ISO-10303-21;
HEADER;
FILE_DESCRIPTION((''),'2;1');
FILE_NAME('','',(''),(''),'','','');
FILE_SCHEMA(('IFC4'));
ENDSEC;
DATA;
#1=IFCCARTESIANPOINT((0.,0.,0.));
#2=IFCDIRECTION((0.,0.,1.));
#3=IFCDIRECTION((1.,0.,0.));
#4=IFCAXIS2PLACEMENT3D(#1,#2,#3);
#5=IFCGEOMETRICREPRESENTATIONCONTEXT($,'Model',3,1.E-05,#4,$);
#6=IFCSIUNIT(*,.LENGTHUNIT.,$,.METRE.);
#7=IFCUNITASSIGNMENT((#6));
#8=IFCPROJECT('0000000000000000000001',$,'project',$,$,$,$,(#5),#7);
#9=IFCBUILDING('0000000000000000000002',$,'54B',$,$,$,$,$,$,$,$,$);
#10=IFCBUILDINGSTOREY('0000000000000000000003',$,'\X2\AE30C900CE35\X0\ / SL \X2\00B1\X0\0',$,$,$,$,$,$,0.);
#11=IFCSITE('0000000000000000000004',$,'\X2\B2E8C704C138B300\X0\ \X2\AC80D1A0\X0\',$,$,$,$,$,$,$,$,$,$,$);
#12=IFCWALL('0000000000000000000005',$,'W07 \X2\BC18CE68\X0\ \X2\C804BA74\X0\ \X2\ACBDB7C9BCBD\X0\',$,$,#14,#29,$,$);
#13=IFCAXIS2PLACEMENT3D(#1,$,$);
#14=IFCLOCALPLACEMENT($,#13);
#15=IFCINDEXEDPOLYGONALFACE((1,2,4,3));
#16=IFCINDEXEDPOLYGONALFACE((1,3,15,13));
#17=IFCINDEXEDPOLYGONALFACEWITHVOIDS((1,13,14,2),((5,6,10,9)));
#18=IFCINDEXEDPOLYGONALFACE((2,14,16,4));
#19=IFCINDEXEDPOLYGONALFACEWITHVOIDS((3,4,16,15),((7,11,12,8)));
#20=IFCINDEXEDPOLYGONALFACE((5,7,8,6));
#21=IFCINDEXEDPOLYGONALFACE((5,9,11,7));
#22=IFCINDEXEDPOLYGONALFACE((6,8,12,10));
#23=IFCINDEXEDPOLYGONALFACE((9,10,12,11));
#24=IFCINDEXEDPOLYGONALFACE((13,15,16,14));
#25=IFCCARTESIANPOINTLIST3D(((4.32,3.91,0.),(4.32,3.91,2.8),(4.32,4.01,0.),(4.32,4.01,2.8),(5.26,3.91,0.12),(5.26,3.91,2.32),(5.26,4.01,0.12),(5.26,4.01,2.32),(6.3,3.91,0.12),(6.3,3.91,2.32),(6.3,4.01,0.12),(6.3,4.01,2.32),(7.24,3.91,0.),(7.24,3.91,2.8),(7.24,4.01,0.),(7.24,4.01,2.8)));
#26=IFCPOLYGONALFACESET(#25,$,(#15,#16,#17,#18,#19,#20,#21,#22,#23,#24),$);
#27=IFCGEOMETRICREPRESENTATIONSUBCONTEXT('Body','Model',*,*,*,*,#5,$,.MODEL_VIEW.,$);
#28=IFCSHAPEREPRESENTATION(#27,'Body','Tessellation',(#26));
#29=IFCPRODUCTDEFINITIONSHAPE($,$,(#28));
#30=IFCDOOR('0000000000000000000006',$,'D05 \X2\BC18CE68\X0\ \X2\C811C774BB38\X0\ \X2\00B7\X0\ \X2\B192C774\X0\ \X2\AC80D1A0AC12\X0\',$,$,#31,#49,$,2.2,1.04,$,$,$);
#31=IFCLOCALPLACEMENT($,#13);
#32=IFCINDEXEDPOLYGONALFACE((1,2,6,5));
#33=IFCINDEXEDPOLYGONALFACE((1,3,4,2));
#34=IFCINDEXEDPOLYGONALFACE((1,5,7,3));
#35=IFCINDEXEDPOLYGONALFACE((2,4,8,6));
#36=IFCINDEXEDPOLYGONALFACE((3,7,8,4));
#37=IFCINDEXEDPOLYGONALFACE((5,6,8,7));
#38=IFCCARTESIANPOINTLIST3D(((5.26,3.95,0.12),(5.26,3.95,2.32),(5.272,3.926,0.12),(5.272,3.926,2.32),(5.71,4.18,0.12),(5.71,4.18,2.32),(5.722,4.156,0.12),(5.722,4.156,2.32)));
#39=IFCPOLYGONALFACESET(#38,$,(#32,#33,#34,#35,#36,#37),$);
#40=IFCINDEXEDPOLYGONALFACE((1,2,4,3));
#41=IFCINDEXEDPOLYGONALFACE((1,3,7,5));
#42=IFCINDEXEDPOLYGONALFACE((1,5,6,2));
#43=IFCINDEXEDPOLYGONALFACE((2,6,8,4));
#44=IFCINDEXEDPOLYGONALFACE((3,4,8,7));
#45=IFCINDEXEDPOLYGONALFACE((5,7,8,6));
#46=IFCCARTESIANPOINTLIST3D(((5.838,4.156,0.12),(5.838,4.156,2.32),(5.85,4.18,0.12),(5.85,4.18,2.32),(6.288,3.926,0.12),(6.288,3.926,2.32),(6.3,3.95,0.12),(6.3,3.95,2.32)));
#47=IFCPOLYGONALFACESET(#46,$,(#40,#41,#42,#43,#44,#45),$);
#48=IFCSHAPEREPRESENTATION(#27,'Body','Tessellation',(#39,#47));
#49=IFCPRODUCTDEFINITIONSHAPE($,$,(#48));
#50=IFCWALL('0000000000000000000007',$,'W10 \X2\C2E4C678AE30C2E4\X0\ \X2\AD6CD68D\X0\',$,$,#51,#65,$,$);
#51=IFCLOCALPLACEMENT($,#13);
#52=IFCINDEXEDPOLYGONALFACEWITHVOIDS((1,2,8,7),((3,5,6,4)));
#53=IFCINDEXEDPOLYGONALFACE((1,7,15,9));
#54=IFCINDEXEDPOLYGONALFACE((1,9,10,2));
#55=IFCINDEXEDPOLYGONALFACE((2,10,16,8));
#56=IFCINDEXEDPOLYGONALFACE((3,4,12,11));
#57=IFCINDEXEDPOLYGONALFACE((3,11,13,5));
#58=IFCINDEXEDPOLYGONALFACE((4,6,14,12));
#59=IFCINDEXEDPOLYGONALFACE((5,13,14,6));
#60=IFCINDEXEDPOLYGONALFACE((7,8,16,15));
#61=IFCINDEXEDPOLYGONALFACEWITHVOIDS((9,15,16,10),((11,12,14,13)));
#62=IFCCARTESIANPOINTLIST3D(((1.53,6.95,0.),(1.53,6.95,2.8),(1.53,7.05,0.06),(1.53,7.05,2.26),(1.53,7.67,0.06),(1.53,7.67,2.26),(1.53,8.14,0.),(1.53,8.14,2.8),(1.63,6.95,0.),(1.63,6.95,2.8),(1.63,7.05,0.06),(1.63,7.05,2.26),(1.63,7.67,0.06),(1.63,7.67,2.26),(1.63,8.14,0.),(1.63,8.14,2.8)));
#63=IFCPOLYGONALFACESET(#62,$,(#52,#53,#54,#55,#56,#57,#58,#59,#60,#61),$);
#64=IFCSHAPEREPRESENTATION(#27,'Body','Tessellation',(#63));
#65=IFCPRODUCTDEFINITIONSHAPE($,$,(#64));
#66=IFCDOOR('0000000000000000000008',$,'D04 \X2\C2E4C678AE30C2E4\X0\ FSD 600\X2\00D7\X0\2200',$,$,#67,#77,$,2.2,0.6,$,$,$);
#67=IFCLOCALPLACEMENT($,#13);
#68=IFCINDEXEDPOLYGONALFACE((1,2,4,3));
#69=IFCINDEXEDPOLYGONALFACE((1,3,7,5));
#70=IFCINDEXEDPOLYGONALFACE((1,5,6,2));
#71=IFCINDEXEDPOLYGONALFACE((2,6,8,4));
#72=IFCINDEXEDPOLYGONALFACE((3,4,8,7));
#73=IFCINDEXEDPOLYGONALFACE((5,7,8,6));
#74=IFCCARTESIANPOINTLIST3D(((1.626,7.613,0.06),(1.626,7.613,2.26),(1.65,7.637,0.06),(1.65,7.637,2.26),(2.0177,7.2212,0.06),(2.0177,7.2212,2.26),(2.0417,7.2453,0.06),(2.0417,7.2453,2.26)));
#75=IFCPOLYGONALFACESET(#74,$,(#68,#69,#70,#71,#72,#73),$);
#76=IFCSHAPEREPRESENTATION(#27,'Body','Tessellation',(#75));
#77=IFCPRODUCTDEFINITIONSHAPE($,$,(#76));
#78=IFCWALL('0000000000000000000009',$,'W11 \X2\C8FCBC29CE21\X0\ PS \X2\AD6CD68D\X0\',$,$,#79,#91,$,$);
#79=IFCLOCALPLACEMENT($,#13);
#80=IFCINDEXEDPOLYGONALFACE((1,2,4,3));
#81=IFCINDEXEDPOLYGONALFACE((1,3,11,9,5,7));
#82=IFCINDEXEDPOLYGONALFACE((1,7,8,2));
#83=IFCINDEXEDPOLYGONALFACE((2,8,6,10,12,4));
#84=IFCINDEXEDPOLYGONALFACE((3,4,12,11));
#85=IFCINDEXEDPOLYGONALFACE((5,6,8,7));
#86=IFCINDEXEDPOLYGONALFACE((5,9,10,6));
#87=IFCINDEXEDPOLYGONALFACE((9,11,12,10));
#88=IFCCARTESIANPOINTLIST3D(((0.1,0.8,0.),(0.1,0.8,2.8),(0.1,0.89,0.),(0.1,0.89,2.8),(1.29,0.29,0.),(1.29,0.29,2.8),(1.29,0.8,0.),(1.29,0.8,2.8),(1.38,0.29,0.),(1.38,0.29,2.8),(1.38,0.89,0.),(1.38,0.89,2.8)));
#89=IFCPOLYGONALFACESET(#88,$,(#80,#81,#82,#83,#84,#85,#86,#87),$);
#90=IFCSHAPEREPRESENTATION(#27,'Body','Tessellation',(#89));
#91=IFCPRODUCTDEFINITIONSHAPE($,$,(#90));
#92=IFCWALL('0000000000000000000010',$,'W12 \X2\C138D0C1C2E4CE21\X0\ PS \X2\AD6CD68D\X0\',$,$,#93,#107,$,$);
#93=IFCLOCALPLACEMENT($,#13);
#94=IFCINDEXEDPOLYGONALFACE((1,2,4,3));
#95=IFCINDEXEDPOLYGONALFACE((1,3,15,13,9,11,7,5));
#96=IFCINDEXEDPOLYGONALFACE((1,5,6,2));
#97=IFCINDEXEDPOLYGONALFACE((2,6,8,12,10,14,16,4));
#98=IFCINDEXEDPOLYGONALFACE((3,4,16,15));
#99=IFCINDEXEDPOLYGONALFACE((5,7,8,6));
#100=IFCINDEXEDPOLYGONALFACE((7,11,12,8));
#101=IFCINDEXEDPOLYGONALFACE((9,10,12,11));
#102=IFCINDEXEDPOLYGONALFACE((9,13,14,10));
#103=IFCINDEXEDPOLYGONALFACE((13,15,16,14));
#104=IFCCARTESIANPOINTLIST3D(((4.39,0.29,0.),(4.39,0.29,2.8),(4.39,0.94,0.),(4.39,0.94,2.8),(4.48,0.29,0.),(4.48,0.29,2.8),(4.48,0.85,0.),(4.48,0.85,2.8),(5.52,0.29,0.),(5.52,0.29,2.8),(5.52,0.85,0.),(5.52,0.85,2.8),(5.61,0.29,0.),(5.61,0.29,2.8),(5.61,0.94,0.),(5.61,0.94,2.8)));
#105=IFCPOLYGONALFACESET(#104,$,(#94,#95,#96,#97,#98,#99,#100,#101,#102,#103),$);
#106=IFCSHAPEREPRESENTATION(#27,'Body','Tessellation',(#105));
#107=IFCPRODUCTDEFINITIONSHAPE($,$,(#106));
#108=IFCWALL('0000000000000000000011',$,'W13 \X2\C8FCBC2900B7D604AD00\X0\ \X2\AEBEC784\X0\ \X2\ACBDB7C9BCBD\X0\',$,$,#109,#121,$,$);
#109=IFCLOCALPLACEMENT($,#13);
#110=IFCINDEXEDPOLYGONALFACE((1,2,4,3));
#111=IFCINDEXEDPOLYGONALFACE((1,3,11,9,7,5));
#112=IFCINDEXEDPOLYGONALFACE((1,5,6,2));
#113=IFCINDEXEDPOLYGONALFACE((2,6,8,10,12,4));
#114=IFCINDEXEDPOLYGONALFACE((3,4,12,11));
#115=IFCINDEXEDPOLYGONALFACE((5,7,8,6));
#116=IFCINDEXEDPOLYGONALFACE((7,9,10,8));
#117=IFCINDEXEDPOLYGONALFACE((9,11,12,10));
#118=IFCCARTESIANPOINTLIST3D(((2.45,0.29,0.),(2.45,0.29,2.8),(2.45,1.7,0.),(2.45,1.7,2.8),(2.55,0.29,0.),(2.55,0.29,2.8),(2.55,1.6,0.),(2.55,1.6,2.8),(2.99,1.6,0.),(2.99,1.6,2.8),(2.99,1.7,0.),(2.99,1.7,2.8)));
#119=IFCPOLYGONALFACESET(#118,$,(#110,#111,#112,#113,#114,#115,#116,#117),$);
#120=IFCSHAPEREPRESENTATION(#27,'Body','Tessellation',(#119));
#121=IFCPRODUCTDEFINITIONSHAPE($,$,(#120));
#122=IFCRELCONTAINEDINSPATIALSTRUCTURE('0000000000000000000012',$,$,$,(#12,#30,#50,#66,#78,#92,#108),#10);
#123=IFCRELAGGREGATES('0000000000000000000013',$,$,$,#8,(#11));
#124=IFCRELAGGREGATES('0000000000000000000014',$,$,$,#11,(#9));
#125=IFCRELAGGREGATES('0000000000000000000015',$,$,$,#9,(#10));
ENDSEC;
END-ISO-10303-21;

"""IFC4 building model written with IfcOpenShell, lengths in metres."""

from ifc_helpers import new_model, si_unit, frame, origin, origin_with_axes, place, context, subcontext, project, spatial, polyline, outline, extrude, element, fill, save


model = new_model("IFC4")

# Units and contexts
model_context = context("Model", 3, precision=1e-05, world=origin_with_axes())
body_context = subcontext(model_context, "Body", "Model", "MODEL_VIEW")
ifc_project = project(units=[si_unit("LENGTHUNIT", "METRE")], contexts=[model_context])

# Site, building, storey
site = spatial("IfcSite", under=ifc_project, Name="단위세대 검토")
building = spatial("IfcBuilding", under=site, Name="54B")
storey = spatial("IfcBuildingStorey", under=building, Name="기준층 / SL ±0", Elevation=0.0)

# Wall, opening, door
wall_1_placement = place(None, origin_with_axes())
wall_1 = element("IfcWall", 1, at=wall_1_placement, inside=storey, Name="W07 반침 전면 경량벽", context=body_context, shape_type="SweptSolid", body=[
    extrude(outline(polyline([(7.24, 3.91), (7.24, 4.01), (4.32, 4.01), (4.32, 3.91), (7.24, 3.91)])), origin(), (0.0, 0.0, 1.0), 2.8),
])
opening_1_placement = place(wall_1_placement, origin_with_axes())
opening_1 = element("IfcOpeningElement", 2, at=opening_1_placement, cuts=wall_1, context=body_context, shape_type="SweptSolid", body=[
    extrude(outline(polyline([(6.3, 3.909), (6.3, 4.011), (5.26, 4.011), (5.26, 3.909), (6.3, 3.909)])), frame((0.0, 0.0, 0.12)), (0.0, 0.0, 1.0), 2.2),
])
door_1_placement = place(None, origin_with_axes())
door_1 = element("IfcDoor", 3, at=door_1_placement, inside=storey, Name="D05 반침 접이문 · 높이 검토값", OverallHeight=2.2, OverallWidth=1.04, context=body_context, shape_type="SweptSolid", body=[
    extrude(outline(polyline([(5.26, 3.95), (5.71, 4.18), (5.722, 4.156), (5.272, 3.926), (5.26, 3.95)])), frame((0.0, 0.0, 0.12)), (0.0, 0.0, 1.0), 2.2),
    extrude(outline(polyline([(6.3, 3.95), (5.85, 4.18), (5.838, 4.156), (6.288, 3.926), (6.3, 3.95)])), frame((0.0, 0.0, 0.12)), (0.0, 0.0, 1.0), 2.2),
])
fill(opening_1, door_1)

# Wall, opening, door
wall_2_placement = place(None, origin_with_axes())
wall_2 = element("IfcWall", 4, at=wall_2_placement, inside=storey, Name="W10 실외기실 구획", context=body_context, shape_type="SweptSolid", body=[
    extrude(outline(polyline([(1.63, 6.95), (1.63, 8.14), (1.53, 8.14), (1.53, 6.95), (1.63, 6.95)])), origin(), (0.0, 0.0, 1.0), 2.8),
])
opening_2_placement = place(wall_2_placement, origin_with_axes())
opening_2 = element("IfcOpeningElement", 5, at=opening_2_placement, cuts=wall_2, context=body_context, shape_type="SweptSolid", body=[
    extrude(outline(polyline([(1.631, 7.05), (1.631, 7.67), (1.529, 7.67), (1.529, 7.05), (1.631, 7.05)])), frame((0.0, 0.0, 0.06)), (0.0, 0.0, 1.0), 2.2),
])
door_2_placement = place(None, origin_with_axes())
door_2 = element("IfcDoor", 6, at=door_2_placement, inside=storey, Name="D04 실외기실 FSD 600×2200", OverallHeight=2.2, OverallWidth=0.6, context=body_context, shape_type="SweptSolid", body=[
    extrude(outline(polyline([(1.626, 7.613), (1.65, 7.637), (2.0417, 7.2453), (2.0177, 7.2212), (1.626, 7.613)])), frame((0.0, 0.0, 0.06)), (0.0, 0.0, 1.0), 2.2),
])
fill(opening_2, door_2)

# Walls
wall_3_placement = place(None, origin_with_axes())
element("IfcWall", 7, at=wall_3_placement, inside=storey, Name="W11 주방측 PS 구획", context=body_context, shape_type="SweptSolid", body=[
    extrude(outline(polyline([(1.29, 0.29), (1.38, 0.29), (1.38, 0.89), (0.1, 0.89), (0.1, 0.8), (1.29, 0.8), (1.29, 0.29)])), origin(), (0.0, 0.0, 1.0), 2.8),
])
wall_4_placement = place(None, origin_with_axes())
element("IfcWall", 8, at=wall_4_placement, inside=storey, Name="W12 세탁실측 PS 구획", context=body_context, shape_type="SweptSolid", body=[
    extrude(outline(polyline([(4.39, 0.29), (4.48, 0.29), (4.48, 0.85), (5.52, 0.85), (5.52, 0.29), (5.61, 0.29), (5.61, 0.94), (4.39, 0.94), (4.39, 0.29)])), origin(), (0.0, 0.0, 1.0), 2.8),
])
wall_5_placement = place(None, origin_with_axes())
element("IfcWall", 9, at=wall_5_placement, inside=storey, Name="W13 주방·현관 꺾임 경량벽", context=body_context, shape_type="SweptSolid", body=[
    extrude(outline(polyline([(2.45, 0.29), (2.55, 0.29), (2.55, 1.6), (2.99, 1.6), (2.99, 1.7), (2.45, 1.7), (2.45, 0.29)])), origin(), (0.0, 0.0, 1.0), 2.8),
])

save(model, "model.ifc")
